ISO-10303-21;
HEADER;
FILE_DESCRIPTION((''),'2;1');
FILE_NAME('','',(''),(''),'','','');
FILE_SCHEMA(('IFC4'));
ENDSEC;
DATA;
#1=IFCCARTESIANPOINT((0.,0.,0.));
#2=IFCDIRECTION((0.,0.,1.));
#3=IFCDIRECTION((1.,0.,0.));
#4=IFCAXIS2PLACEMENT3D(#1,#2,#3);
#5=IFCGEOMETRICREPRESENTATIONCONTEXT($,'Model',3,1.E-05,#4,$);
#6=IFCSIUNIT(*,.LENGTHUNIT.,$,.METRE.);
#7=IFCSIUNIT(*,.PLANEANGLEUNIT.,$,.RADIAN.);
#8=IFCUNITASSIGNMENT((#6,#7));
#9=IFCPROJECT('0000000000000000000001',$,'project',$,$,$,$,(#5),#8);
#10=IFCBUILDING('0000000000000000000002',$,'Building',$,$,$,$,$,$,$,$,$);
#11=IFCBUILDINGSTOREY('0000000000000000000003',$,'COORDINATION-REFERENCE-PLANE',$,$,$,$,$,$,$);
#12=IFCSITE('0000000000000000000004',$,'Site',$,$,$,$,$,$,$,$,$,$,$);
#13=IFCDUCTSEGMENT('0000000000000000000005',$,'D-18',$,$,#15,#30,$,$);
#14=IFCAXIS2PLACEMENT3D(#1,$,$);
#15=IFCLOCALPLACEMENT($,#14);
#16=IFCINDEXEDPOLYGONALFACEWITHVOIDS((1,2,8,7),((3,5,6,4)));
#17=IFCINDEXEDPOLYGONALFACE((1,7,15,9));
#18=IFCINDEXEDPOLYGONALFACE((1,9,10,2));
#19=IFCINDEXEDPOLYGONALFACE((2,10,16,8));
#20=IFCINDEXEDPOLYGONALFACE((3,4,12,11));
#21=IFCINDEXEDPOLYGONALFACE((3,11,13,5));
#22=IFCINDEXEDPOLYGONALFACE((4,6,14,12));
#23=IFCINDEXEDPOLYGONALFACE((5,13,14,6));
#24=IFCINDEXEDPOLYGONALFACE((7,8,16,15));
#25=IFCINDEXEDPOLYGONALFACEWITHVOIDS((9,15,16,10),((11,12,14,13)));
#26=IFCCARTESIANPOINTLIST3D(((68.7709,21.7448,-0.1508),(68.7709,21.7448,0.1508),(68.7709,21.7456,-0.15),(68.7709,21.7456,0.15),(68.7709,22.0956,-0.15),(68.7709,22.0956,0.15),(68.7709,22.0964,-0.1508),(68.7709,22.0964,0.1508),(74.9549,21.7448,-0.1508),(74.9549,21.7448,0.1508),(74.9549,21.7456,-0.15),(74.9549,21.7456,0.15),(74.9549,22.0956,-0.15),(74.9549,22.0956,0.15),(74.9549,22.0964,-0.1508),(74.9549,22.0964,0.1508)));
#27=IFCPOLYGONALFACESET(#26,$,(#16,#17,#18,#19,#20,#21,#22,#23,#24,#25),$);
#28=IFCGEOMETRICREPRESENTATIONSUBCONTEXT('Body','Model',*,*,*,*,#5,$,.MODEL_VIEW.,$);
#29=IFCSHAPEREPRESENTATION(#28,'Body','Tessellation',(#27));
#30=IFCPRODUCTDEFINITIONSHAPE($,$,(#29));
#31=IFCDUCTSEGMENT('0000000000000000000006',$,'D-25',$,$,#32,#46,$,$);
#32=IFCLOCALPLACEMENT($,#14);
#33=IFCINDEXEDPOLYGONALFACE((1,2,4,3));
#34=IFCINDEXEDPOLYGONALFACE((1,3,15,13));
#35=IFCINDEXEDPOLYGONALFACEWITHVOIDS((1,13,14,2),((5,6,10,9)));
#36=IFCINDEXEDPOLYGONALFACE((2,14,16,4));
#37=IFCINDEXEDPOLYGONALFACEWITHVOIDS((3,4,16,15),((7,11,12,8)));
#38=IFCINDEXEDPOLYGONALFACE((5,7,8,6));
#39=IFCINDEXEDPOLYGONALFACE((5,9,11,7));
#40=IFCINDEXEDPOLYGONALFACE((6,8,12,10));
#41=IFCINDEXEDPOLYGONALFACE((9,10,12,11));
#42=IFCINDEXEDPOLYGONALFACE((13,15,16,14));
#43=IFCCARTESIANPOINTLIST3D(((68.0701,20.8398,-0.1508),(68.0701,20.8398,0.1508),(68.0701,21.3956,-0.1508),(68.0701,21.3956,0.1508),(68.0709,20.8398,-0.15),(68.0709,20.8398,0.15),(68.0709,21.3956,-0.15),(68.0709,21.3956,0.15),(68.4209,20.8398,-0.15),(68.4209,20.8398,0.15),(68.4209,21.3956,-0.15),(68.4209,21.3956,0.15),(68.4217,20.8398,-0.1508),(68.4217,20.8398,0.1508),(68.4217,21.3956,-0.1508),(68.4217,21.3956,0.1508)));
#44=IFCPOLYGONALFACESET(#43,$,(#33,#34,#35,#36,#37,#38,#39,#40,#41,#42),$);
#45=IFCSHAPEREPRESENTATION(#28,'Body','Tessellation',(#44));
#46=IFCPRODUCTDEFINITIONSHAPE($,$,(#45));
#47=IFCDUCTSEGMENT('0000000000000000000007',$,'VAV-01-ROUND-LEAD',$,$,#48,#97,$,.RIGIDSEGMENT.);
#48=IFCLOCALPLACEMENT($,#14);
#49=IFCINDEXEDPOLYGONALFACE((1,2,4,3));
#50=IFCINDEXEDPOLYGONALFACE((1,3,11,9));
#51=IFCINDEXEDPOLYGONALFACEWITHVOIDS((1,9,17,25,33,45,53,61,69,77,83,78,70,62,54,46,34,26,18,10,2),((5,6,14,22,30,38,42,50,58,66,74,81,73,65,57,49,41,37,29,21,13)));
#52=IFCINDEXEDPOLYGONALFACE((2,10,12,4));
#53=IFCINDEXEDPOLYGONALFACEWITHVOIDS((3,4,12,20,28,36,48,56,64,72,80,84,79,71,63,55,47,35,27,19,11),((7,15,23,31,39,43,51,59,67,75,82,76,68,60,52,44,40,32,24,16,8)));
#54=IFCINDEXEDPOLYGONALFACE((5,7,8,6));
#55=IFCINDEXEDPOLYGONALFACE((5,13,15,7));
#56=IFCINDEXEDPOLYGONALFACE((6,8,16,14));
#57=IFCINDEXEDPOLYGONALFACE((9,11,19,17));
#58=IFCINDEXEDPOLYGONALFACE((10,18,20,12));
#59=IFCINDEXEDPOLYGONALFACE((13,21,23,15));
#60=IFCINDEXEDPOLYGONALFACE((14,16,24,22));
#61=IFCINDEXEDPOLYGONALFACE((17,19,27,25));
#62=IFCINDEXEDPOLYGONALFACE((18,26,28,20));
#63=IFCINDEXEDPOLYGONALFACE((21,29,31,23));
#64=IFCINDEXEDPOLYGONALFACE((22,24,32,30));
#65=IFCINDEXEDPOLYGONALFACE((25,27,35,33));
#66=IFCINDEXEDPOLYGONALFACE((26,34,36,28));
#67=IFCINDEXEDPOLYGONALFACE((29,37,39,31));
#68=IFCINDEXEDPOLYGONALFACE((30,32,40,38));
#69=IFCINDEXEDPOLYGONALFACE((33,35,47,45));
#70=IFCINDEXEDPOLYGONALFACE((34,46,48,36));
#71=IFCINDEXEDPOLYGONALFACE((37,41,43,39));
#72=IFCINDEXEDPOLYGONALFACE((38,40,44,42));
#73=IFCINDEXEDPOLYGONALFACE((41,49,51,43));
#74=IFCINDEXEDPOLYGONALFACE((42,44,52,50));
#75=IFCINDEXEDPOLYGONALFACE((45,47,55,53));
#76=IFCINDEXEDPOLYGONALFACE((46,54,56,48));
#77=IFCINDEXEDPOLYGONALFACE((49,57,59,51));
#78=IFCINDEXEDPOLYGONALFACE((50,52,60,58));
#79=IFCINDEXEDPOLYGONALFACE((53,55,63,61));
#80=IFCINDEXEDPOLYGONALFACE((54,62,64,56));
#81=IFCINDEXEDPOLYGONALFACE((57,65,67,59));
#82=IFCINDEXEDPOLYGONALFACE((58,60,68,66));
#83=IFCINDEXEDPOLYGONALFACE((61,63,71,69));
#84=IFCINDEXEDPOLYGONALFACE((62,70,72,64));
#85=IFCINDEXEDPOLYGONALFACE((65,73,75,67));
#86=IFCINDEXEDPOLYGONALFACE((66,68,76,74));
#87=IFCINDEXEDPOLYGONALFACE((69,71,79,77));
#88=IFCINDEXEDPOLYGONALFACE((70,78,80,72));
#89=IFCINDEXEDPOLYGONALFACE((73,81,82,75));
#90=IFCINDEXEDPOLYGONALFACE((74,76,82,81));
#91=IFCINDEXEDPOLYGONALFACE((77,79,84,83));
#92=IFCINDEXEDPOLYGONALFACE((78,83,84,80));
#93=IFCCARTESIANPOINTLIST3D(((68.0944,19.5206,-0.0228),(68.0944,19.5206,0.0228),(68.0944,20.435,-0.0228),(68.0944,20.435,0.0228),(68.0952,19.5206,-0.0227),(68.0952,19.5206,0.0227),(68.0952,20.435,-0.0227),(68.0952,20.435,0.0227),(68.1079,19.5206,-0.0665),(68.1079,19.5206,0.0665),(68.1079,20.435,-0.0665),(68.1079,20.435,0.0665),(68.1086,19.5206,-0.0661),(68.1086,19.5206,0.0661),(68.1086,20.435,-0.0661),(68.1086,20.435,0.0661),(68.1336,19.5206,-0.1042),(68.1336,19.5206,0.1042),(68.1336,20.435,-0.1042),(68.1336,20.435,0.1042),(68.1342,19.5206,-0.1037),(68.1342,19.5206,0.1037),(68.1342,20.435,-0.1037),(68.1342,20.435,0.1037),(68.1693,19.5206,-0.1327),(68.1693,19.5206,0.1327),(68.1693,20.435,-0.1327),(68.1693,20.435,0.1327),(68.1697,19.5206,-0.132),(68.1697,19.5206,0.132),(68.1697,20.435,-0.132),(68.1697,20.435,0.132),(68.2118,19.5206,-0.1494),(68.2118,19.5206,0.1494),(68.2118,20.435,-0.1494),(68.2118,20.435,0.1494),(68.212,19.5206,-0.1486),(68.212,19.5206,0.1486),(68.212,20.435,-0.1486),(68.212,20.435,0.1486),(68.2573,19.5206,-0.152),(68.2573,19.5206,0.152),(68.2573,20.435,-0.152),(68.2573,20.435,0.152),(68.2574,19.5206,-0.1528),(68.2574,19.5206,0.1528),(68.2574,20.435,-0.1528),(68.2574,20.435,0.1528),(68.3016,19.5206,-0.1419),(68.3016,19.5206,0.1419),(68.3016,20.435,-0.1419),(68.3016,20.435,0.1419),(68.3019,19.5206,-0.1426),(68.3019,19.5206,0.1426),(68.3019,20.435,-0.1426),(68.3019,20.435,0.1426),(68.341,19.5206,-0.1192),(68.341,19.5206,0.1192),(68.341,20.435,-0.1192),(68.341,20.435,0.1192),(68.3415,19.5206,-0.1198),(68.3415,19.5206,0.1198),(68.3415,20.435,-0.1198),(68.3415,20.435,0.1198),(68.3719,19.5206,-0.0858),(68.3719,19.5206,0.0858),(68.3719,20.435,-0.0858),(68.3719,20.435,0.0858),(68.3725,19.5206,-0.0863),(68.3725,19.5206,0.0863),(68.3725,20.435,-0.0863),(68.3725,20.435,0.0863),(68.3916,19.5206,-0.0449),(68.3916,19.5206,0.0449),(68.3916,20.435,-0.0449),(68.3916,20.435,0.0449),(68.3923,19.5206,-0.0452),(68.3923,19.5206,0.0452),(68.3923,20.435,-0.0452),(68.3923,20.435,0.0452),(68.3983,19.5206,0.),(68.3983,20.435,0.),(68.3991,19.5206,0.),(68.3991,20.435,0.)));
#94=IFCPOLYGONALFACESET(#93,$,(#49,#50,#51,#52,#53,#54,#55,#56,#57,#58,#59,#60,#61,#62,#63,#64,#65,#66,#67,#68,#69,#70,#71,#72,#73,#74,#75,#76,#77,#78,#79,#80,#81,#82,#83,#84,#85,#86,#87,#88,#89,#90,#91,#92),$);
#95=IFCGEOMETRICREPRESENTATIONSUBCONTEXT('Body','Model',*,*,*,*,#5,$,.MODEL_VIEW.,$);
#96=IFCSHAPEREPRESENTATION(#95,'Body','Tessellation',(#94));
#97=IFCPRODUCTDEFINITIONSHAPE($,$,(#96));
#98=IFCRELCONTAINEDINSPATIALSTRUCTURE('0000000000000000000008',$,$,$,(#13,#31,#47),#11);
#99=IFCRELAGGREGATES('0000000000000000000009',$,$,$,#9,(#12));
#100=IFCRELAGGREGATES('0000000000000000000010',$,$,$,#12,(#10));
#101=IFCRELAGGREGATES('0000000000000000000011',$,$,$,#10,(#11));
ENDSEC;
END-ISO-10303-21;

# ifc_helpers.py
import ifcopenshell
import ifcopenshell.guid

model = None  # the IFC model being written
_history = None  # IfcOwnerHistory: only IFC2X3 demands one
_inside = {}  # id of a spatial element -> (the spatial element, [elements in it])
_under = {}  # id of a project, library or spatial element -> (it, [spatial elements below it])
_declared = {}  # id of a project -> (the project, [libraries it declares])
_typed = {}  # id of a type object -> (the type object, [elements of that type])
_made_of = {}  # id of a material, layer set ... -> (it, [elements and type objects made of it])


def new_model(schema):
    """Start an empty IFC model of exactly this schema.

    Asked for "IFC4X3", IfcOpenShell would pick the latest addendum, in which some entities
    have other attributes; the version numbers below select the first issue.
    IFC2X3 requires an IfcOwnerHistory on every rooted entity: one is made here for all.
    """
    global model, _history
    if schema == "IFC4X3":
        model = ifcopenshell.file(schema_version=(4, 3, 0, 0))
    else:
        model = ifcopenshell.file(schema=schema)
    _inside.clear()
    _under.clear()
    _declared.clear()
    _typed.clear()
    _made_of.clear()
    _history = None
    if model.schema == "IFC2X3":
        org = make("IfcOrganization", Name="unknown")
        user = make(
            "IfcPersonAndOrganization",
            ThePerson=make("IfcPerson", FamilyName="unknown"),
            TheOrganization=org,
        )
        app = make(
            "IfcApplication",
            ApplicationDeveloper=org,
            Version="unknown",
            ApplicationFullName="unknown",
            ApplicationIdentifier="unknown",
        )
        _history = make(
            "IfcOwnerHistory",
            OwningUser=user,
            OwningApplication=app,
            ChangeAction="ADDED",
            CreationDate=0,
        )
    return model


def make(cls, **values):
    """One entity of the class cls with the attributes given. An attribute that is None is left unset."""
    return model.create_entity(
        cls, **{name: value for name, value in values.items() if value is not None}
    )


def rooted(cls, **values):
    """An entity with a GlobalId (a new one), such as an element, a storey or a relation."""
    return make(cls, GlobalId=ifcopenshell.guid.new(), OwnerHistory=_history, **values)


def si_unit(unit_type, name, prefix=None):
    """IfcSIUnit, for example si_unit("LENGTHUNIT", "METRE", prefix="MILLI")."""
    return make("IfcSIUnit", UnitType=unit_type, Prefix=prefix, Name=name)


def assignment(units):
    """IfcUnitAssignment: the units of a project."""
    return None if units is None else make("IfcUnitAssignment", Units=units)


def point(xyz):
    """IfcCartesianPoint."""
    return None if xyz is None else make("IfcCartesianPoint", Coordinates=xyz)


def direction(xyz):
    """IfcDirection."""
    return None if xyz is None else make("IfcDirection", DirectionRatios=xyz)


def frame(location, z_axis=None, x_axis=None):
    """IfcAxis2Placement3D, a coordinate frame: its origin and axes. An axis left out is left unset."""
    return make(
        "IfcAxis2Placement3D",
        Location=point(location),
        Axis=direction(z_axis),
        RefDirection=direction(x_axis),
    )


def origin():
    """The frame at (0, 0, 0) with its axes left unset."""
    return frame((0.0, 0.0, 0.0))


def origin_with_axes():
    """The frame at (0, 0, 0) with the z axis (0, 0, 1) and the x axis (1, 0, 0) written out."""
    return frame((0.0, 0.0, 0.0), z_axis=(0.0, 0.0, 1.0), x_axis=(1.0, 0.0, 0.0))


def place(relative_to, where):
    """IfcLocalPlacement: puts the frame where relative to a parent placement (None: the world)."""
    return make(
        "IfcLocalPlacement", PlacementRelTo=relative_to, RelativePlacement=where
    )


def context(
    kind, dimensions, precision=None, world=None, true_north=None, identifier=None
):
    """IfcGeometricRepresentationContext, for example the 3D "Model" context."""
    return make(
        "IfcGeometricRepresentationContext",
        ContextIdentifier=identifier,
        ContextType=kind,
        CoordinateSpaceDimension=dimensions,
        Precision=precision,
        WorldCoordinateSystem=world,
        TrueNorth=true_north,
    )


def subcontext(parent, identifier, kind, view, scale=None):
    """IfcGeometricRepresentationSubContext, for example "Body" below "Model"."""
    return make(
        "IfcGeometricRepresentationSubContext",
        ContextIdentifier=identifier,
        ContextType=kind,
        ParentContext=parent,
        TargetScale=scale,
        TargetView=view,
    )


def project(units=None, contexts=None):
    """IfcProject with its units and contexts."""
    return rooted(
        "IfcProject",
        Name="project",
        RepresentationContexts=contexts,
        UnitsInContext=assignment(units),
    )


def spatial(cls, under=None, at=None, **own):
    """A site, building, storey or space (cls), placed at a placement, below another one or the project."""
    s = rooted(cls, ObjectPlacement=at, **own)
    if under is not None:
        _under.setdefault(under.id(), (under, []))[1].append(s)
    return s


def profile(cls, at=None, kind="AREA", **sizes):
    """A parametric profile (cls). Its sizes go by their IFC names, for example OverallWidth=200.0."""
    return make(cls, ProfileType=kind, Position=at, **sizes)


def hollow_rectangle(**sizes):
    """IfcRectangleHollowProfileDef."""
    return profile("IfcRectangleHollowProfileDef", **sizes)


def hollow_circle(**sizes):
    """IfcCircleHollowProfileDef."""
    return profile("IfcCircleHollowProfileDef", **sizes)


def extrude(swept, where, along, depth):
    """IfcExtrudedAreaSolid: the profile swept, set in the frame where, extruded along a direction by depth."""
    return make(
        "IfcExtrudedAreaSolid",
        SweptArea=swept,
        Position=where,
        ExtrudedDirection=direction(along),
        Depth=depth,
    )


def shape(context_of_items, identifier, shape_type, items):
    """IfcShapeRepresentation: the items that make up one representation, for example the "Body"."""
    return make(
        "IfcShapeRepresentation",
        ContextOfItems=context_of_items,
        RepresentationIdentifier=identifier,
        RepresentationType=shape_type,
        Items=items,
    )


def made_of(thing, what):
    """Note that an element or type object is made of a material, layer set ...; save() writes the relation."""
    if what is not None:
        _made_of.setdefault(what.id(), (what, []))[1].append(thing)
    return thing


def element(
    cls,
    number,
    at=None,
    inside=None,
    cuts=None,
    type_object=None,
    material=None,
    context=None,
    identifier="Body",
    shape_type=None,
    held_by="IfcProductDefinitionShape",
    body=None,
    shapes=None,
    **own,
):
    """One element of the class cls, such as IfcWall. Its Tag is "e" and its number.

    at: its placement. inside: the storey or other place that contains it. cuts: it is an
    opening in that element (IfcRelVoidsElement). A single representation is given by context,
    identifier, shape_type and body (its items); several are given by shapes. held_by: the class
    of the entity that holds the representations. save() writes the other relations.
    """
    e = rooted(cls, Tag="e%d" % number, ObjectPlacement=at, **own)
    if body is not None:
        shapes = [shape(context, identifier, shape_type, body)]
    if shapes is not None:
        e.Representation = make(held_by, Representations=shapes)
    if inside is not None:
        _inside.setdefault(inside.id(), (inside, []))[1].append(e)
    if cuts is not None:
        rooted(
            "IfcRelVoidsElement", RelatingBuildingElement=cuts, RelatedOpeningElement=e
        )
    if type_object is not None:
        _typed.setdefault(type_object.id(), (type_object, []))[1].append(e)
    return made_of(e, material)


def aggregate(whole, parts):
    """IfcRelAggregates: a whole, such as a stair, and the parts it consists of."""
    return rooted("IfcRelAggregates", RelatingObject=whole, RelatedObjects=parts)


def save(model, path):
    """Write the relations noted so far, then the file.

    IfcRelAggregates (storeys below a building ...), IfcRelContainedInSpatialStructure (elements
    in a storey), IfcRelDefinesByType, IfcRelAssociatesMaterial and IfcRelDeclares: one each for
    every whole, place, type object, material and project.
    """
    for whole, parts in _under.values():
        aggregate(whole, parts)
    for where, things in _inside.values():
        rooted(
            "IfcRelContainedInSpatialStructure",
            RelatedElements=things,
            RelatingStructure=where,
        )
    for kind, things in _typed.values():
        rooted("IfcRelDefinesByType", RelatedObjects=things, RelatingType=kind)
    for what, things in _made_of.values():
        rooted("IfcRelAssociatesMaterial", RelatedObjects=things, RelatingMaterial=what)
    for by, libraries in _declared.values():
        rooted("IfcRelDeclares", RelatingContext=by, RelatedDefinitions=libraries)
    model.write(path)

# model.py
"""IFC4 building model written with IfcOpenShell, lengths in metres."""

from ifc_helpers import new_model, si_unit, frame, origin, origin_with_axes, place, context, subcontext, project, spatial, hollow_rectangle, hollow_circle, extrude, element, save


model = new_model("IFC4")

# Units and contexts
model_context = context("Model", 3, precision=1e-05, world=origin_with_axes())
body_context_1 = subcontext(model_context, "Body", "Model", "MODEL_VIEW")
body_context_2 = subcontext(model_context, "Body", "Model", "MODEL_VIEW")
ifc_project = project(units=[si_unit("LENGTHUNIT", "METRE"), si_unit("PLANEANGLEUNIT", "RADIAN")], contexts=[model_context])

# Site, building, storey
site = spatial("IfcSite", under=ifc_project, Name="Site")
building = spatial("IfcBuilding", under=site, Name="Building")
storey = spatial("IfcBuildingStorey", under=building, Name="COORDINATION-REFERENCE-PLANE")

# Duct segments
duct_segment_1_placement = place(None, frame((68.7709, 21.9206, 0.0), z_axis=(1.0, 0.0, 0.0), x_axis=(0.0, 1.0, 0.0)))
element("IfcDuctSegment", 1, at=duct_segment_1_placement, inside=storey, Name="D-18", context=body_context_1, shape_type="SweptSolid", body=[
    extrude(hollow_rectangle(XDim=0.3516, YDim=0.3016, WallThickness=0.0008), origin(), (0.0, 0.0, 1.0), 6.1839),
])
duct_segment_2_placement = place(None, frame((68.2459, 20.8398, 0.0), z_axis=(0.0, 1.0, 0.0), x_axis=(1.0, 0.0, 0.0)))
element("IfcDuctSegment", 2, at=duct_segment_2_placement, inside=storey, Name="D-25", context=body_context_1, shape_type="SweptSolid", body=[
    extrude(hollow_rectangle(XDim=0.3516, YDim=0.3016, WallThickness=0.0008), origin(), (0.0, 0.0, 1.0), 0.5558),
])

# Duct segment
duct_segment_3_placement = place(None, frame((68.2459, 20.435, 0.0), z_axis=(0.0, -1.0, 0.0), x_axis=(1.0, 0.0, 0.0)))
element("IfcDuctSegment", 3, at=duct_segment_3_placement, inside=storey, Name="VAV-01-ROUND-LEAD", PredefinedType="RIGIDSEGMENT", context=body_context_2, shape_type="SweptSolid", body=[
    extrude(hollow_circle(Radius=0.1532, WallThickness=0.0008), origin(), (0.0, 0.0, 1.0), 0.9144),
])

save(model, "model.ifc")
